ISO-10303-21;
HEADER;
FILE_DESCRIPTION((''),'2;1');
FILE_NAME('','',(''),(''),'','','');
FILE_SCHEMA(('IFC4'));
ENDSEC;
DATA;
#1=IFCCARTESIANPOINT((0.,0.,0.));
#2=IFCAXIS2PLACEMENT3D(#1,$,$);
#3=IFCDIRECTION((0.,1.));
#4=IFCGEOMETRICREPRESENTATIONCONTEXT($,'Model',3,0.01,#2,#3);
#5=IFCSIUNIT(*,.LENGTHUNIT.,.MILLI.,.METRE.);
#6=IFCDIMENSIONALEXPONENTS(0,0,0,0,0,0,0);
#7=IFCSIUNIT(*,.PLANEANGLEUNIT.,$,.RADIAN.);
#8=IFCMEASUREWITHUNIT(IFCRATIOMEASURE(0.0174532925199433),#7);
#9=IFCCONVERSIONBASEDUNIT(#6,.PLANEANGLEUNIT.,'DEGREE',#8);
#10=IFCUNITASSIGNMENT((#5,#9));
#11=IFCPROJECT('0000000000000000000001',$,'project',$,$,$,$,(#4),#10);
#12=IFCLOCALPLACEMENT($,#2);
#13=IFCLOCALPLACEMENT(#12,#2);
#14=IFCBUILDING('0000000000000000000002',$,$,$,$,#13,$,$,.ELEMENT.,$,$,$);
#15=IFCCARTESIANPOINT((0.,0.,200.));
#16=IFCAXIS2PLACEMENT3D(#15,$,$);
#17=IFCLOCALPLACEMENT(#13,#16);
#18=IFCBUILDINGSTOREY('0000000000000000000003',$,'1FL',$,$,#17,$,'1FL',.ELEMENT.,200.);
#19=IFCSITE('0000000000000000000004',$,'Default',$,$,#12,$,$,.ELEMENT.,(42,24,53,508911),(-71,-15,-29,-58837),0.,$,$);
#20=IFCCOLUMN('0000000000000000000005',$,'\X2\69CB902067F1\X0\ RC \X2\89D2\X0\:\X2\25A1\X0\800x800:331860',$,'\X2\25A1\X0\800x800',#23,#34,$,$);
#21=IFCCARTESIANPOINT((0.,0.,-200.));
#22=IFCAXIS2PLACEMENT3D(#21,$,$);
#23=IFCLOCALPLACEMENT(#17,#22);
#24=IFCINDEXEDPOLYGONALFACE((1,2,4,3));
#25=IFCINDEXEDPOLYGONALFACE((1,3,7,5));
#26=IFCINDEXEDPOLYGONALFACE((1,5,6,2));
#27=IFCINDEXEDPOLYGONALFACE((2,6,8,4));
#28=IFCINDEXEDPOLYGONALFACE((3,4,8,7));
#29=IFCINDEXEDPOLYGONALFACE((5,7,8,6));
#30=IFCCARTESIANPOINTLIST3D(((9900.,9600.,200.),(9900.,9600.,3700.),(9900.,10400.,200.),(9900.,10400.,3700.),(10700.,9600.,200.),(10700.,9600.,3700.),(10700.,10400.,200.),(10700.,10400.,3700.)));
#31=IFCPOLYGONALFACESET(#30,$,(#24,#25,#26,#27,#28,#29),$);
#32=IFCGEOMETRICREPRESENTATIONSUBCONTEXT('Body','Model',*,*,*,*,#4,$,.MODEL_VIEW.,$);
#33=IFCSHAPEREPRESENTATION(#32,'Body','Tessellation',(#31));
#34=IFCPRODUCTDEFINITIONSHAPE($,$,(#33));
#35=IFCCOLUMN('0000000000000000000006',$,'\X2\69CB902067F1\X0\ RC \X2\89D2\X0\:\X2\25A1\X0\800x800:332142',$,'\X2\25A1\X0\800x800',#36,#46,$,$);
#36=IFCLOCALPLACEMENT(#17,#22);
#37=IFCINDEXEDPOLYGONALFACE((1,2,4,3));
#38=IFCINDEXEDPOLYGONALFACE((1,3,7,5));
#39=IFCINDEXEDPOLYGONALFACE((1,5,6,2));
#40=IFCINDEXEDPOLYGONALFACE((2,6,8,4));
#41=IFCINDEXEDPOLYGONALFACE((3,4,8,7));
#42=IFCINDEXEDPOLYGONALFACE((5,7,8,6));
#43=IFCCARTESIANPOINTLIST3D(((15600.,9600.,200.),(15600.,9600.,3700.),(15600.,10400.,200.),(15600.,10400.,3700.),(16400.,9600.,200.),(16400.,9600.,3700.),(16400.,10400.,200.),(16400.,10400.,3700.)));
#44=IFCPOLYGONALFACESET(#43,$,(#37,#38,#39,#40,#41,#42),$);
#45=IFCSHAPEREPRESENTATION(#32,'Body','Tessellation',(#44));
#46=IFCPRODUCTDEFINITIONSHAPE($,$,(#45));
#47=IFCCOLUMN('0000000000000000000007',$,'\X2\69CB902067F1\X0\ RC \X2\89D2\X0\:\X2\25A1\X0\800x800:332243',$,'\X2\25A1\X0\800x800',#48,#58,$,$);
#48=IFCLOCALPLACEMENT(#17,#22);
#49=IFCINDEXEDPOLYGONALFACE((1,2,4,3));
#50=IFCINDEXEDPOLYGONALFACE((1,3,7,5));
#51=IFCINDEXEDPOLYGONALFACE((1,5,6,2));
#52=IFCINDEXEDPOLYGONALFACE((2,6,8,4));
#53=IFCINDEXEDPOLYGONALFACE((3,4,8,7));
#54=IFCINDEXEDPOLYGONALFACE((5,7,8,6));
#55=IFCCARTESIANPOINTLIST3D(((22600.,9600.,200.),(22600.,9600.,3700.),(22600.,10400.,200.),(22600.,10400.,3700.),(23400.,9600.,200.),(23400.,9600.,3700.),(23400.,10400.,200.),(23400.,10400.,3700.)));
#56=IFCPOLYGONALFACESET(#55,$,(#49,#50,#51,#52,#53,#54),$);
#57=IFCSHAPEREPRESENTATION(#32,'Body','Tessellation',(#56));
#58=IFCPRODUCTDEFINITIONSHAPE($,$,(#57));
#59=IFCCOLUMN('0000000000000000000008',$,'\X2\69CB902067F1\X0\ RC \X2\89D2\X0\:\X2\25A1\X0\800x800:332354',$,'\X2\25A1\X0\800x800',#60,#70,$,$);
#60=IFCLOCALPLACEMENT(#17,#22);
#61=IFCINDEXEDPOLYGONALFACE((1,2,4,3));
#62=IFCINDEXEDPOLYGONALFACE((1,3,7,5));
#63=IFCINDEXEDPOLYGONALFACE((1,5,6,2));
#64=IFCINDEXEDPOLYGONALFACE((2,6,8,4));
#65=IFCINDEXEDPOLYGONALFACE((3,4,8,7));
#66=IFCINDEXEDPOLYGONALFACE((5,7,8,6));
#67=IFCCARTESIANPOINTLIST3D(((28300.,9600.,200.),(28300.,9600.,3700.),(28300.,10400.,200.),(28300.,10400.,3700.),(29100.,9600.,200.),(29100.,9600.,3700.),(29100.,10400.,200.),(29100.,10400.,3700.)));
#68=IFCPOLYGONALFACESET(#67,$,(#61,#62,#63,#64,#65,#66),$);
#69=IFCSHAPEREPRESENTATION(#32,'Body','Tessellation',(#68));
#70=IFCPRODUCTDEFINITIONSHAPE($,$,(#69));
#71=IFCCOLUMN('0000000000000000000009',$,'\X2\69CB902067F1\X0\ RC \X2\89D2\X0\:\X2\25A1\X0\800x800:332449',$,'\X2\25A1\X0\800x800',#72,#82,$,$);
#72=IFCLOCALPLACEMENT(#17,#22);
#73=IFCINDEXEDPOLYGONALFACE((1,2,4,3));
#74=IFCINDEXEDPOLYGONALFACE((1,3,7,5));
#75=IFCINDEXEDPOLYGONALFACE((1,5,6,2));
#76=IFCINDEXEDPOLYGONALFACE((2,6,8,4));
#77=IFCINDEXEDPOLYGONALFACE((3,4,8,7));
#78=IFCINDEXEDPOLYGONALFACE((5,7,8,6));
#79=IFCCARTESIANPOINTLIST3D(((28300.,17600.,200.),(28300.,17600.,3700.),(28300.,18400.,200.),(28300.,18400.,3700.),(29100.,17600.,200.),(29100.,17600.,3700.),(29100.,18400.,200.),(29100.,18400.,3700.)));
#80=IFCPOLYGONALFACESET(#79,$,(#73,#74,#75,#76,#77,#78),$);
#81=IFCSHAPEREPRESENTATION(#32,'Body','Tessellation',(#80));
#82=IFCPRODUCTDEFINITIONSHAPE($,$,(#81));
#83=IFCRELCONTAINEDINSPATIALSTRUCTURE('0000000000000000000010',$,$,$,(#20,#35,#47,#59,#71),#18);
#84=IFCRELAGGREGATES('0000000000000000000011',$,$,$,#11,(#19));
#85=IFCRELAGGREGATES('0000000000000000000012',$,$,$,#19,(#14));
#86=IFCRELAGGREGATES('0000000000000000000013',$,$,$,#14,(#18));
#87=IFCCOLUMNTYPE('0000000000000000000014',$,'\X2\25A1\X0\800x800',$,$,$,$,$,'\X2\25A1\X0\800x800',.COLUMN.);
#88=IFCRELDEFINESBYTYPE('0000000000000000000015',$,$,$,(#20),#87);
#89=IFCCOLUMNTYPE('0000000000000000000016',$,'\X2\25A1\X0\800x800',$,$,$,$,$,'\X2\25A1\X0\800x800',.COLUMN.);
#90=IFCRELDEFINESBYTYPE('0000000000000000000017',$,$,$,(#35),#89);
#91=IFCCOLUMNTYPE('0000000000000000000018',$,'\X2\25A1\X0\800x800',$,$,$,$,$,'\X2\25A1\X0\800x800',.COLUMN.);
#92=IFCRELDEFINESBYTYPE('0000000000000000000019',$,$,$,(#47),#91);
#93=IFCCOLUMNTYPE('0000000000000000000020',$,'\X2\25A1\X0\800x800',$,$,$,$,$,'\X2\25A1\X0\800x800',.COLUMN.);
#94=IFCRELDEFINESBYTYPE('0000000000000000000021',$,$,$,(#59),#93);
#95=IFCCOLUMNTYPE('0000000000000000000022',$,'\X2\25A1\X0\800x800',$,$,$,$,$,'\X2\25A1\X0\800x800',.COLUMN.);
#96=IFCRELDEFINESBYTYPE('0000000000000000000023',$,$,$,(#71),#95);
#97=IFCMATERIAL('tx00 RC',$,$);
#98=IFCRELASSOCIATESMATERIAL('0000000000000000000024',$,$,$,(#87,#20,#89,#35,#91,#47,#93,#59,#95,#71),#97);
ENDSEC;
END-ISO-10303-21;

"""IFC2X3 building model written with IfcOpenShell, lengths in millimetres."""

from ifc_helpers import new_model, entity, si_unit, converted_unit, direction, frame, frame_2d, origin, origin_2d_with_axis, place, context, subcontext, project, spatial, rectangle, extrude, source, transform, mapped, material, type_object, type_shapes, element, save


model = new_model("IFC2X3")

# Units and contexts
model_context = context("Model", 3, precision=0.01, world=origin(), true_north=direction((0.0, 1.0)))
body_context = subcontext(model_context, "Body", "Model", "MODEL_VIEW")
ifc_project = project(units=[si_unit("LENGTHUNIT", "METRE", prefix="MILLI"), converted_unit("PLANEANGLEUNIT", "DEGREE", entity("IfcRatioMeasure", 0.0174532925199433), si_unit("PLANEANGLEUNIT", "RADIAN"), dimensions=[0, 0, 0, 0, 0, 0, 0])], contexts=[model_context])

# Site, building, storey
site_placement = place(None, origin())
site = spatial("IfcSite", under=ifc_project, at=site_placement, Name="Default", CompositionType="ELEMENT", RefLatitude=(42, 24, 53, 508911), RefLongitude=(-71, -15, -29, -58837), RefElevation=0.0)
building_placement = place(site_placement, origin())
building = spatial("IfcBuilding", under=site, at=building_placement, CompositionType="ELEMENT")
storey_placement = place(building_placement, frame((0.0, 0.0, 200.0)))
storey = spatial("IfcBuildingStorey", under=building, at=storey_placement, Name="1FL", LongName="1FL", CompositionType="ELEMENT", Elevation=200.0)

# Columns
ifc_material_1 = material(Name="tx00 RC")
column_type_1 = type_object("IfcColumnType", Name="□800x800", ElementType="□800x800", PredefinedType="COLUMN", material=ifc_material_1)
shared_shape_1 = source(origin(), body_context, "Body", "SweptSolid", [
    extrude(rectangle(XDim=800.0, YDim=800.0, at=frame_2d((0.0, 0.0), x_axis=(1.0, 0.0))), frame((10300.0, 10000.0, 200.0), z_axis=(0.0, 0.0, 1.0), x_axis=(0.0, -1.0, 0.0)), (0.0, 0.0, 1.0), 3500.0),
])
type_shapes(column_type_1, [shared_shape_1])
column_1_placement = place(storey_placement, frame((0.0, 0.0, -200.0)))
element("IfcColumn", 1, at=column_1_placement, inside=storey, type_object=column_type_1, material=ifc_material_1, Name="構造柱 RC 角:□800x800:331860", ObjectType="□800x800", context=body_context, shape_type="MappedRepresentation", body=[
    mapped(shared_shape_1, transform((0.0, 0.0, 0.0), scale=1.0)),
])
column_type_2 = type_object("IfcColumnType", Name="□800x800", ElementType="□800x800", PredefinedType="COLUMN", material=ifc_material_1)
shared_shape_2 = source(origin(), body_context, "Body", "SweptSolid", [
    extrude(rectangle(XDim=800.0, YDim=800.0, at=frame_2d((0.0, 0.0), x_axis=(1.0, 0.0))), frame((16000.0, 10000.0, 200.0), z_axis=(0.0, 0.0, 1.0), x_axis=(0.0, -1.0, 0.0)), (0.0, 0.0, 1.0), 3500.0),
])
type_shapes(column_type_2, [shared_shape_2])
column_2_placement = place(storey_placement, frame((0.0, 0.0, -200.0)))
element("IfcColumn", 2, at=column_2_placement, inside=storey, type_object=column_type_2, material=ifc_material_1, Name="構造柱 RC 角:□800x800:332142", ObjectType="□800x800", context=body_context, shape_type="MappedRepresentation", body=[
    mapped(shared_shape_2, transform((0.0, 0.0, 0.0), scale=1.0)),
])
column_type_3 = type_object("IfcColumnType", Name="□800x800", ElementType="□800x800", PredefinedType="COLUMN", material=ifc_material_1)
shared_shape_3 = source(origin(), body_context, "Body", "SweptSolid", [
    extrude(rectangle(XDim=800.0, YDim=800.0, at=origin_2d_with_axis()), frame((23000.0, 10000.0, 200.0), z_axis=(0.0, 0.0, 1.0), x_axis=(0.0, -1.0, 0.0)), (0.0, 0.0, 1.0), 3500.0),
])
type_shapes(column_type_3, [shared_shape_3])
column_3_placement = place(storey_placement, frame((0.0, 0.0, -200.0)))
element("IfcColumn", 3, at=column_3_placement, inside=storey, type_object=column_type_3, material=ifc_material_1, Name="構造柱 RC 角:□800x800:332243", ObjectType="□800x800", context=body_context, shape_type="MappedRepresentation", body=[
    mapped(shared_shape_3, transform((0.0, 0.0, 0.0), scale=1.0)),
])
column_type_4 = type_object("IfcColumnType", Name="□800x800", ElementType="□800x800", PredefinedType="COLUMN", material=ifc_material_1)
shared_shape_4 = source(origin(), body_context, "Body", "SweptSolid", [
    extrude(rectangle(XDim=800.0, YDim=800.0, at=origin_2d_with_axis()), frame((28700.0, 10000.0, 200.0), z_axis=(0.0, 0.0, 1.0), x_axis=(0.0, -1.0, 0.0)), (0.0, 0.0, 1.0), 3500.0),
])
type_shapes(column_type_4, [shared_shape_4])
column_4_placement = place(storey_placement, frame((0.0, 0.0, -200.0)))
element("IfcColumn", 4, at=column_4_placement, inside=storey, type_object=column_type_4, material=ifc_material_1, Name="構造柱 RC 角:□800x800:332354", ObjectType="□800x800", context=body_context, shape_type="MappedRepresentation", body=[
    mapped(shared_shape_4, transform((0.0, 0.0, 0.0), scale=1.0)),
])
column_type_5 = type_object("IfcColumnType", Name="□800x800", ElementType="□800x800", PredefinedType="COLUMN", material=ifc_material_1)
shared_shape_5 = source(origin(), body_context, "Body", "SweptSolid", [
    extrude(rectangle(XDim=800.0, YDim=800.0, at=origin_2d_with_axis()), frame((28700.0, 18000.0, 200.0), z_axis=(0.0, 0.0, 1.0), x_axis=(0.0, -1.0, 0.0)), (0.0, 0.0, 1.0), 3500.0),
])
type_shapes(column_type_5, [shared_shape_5])
column_5_placement = place(storey_placement, frame((0.0, 0.0, -200.0)))
element("IfcColumn", 5, at=column_5_placement, inside=storey, type_object=column_type_5, material=ifc_material_1, Name="構造柱 RC 角:□800x800:332449", ObjectType="□800x800", context=body_context, shape_type="MappedRepresentation", body=[
    mapped(shared_shape_5, transform((0.0, 0.0, 0.0), scale=1.0)),
])

save(model, "model.ifc")
